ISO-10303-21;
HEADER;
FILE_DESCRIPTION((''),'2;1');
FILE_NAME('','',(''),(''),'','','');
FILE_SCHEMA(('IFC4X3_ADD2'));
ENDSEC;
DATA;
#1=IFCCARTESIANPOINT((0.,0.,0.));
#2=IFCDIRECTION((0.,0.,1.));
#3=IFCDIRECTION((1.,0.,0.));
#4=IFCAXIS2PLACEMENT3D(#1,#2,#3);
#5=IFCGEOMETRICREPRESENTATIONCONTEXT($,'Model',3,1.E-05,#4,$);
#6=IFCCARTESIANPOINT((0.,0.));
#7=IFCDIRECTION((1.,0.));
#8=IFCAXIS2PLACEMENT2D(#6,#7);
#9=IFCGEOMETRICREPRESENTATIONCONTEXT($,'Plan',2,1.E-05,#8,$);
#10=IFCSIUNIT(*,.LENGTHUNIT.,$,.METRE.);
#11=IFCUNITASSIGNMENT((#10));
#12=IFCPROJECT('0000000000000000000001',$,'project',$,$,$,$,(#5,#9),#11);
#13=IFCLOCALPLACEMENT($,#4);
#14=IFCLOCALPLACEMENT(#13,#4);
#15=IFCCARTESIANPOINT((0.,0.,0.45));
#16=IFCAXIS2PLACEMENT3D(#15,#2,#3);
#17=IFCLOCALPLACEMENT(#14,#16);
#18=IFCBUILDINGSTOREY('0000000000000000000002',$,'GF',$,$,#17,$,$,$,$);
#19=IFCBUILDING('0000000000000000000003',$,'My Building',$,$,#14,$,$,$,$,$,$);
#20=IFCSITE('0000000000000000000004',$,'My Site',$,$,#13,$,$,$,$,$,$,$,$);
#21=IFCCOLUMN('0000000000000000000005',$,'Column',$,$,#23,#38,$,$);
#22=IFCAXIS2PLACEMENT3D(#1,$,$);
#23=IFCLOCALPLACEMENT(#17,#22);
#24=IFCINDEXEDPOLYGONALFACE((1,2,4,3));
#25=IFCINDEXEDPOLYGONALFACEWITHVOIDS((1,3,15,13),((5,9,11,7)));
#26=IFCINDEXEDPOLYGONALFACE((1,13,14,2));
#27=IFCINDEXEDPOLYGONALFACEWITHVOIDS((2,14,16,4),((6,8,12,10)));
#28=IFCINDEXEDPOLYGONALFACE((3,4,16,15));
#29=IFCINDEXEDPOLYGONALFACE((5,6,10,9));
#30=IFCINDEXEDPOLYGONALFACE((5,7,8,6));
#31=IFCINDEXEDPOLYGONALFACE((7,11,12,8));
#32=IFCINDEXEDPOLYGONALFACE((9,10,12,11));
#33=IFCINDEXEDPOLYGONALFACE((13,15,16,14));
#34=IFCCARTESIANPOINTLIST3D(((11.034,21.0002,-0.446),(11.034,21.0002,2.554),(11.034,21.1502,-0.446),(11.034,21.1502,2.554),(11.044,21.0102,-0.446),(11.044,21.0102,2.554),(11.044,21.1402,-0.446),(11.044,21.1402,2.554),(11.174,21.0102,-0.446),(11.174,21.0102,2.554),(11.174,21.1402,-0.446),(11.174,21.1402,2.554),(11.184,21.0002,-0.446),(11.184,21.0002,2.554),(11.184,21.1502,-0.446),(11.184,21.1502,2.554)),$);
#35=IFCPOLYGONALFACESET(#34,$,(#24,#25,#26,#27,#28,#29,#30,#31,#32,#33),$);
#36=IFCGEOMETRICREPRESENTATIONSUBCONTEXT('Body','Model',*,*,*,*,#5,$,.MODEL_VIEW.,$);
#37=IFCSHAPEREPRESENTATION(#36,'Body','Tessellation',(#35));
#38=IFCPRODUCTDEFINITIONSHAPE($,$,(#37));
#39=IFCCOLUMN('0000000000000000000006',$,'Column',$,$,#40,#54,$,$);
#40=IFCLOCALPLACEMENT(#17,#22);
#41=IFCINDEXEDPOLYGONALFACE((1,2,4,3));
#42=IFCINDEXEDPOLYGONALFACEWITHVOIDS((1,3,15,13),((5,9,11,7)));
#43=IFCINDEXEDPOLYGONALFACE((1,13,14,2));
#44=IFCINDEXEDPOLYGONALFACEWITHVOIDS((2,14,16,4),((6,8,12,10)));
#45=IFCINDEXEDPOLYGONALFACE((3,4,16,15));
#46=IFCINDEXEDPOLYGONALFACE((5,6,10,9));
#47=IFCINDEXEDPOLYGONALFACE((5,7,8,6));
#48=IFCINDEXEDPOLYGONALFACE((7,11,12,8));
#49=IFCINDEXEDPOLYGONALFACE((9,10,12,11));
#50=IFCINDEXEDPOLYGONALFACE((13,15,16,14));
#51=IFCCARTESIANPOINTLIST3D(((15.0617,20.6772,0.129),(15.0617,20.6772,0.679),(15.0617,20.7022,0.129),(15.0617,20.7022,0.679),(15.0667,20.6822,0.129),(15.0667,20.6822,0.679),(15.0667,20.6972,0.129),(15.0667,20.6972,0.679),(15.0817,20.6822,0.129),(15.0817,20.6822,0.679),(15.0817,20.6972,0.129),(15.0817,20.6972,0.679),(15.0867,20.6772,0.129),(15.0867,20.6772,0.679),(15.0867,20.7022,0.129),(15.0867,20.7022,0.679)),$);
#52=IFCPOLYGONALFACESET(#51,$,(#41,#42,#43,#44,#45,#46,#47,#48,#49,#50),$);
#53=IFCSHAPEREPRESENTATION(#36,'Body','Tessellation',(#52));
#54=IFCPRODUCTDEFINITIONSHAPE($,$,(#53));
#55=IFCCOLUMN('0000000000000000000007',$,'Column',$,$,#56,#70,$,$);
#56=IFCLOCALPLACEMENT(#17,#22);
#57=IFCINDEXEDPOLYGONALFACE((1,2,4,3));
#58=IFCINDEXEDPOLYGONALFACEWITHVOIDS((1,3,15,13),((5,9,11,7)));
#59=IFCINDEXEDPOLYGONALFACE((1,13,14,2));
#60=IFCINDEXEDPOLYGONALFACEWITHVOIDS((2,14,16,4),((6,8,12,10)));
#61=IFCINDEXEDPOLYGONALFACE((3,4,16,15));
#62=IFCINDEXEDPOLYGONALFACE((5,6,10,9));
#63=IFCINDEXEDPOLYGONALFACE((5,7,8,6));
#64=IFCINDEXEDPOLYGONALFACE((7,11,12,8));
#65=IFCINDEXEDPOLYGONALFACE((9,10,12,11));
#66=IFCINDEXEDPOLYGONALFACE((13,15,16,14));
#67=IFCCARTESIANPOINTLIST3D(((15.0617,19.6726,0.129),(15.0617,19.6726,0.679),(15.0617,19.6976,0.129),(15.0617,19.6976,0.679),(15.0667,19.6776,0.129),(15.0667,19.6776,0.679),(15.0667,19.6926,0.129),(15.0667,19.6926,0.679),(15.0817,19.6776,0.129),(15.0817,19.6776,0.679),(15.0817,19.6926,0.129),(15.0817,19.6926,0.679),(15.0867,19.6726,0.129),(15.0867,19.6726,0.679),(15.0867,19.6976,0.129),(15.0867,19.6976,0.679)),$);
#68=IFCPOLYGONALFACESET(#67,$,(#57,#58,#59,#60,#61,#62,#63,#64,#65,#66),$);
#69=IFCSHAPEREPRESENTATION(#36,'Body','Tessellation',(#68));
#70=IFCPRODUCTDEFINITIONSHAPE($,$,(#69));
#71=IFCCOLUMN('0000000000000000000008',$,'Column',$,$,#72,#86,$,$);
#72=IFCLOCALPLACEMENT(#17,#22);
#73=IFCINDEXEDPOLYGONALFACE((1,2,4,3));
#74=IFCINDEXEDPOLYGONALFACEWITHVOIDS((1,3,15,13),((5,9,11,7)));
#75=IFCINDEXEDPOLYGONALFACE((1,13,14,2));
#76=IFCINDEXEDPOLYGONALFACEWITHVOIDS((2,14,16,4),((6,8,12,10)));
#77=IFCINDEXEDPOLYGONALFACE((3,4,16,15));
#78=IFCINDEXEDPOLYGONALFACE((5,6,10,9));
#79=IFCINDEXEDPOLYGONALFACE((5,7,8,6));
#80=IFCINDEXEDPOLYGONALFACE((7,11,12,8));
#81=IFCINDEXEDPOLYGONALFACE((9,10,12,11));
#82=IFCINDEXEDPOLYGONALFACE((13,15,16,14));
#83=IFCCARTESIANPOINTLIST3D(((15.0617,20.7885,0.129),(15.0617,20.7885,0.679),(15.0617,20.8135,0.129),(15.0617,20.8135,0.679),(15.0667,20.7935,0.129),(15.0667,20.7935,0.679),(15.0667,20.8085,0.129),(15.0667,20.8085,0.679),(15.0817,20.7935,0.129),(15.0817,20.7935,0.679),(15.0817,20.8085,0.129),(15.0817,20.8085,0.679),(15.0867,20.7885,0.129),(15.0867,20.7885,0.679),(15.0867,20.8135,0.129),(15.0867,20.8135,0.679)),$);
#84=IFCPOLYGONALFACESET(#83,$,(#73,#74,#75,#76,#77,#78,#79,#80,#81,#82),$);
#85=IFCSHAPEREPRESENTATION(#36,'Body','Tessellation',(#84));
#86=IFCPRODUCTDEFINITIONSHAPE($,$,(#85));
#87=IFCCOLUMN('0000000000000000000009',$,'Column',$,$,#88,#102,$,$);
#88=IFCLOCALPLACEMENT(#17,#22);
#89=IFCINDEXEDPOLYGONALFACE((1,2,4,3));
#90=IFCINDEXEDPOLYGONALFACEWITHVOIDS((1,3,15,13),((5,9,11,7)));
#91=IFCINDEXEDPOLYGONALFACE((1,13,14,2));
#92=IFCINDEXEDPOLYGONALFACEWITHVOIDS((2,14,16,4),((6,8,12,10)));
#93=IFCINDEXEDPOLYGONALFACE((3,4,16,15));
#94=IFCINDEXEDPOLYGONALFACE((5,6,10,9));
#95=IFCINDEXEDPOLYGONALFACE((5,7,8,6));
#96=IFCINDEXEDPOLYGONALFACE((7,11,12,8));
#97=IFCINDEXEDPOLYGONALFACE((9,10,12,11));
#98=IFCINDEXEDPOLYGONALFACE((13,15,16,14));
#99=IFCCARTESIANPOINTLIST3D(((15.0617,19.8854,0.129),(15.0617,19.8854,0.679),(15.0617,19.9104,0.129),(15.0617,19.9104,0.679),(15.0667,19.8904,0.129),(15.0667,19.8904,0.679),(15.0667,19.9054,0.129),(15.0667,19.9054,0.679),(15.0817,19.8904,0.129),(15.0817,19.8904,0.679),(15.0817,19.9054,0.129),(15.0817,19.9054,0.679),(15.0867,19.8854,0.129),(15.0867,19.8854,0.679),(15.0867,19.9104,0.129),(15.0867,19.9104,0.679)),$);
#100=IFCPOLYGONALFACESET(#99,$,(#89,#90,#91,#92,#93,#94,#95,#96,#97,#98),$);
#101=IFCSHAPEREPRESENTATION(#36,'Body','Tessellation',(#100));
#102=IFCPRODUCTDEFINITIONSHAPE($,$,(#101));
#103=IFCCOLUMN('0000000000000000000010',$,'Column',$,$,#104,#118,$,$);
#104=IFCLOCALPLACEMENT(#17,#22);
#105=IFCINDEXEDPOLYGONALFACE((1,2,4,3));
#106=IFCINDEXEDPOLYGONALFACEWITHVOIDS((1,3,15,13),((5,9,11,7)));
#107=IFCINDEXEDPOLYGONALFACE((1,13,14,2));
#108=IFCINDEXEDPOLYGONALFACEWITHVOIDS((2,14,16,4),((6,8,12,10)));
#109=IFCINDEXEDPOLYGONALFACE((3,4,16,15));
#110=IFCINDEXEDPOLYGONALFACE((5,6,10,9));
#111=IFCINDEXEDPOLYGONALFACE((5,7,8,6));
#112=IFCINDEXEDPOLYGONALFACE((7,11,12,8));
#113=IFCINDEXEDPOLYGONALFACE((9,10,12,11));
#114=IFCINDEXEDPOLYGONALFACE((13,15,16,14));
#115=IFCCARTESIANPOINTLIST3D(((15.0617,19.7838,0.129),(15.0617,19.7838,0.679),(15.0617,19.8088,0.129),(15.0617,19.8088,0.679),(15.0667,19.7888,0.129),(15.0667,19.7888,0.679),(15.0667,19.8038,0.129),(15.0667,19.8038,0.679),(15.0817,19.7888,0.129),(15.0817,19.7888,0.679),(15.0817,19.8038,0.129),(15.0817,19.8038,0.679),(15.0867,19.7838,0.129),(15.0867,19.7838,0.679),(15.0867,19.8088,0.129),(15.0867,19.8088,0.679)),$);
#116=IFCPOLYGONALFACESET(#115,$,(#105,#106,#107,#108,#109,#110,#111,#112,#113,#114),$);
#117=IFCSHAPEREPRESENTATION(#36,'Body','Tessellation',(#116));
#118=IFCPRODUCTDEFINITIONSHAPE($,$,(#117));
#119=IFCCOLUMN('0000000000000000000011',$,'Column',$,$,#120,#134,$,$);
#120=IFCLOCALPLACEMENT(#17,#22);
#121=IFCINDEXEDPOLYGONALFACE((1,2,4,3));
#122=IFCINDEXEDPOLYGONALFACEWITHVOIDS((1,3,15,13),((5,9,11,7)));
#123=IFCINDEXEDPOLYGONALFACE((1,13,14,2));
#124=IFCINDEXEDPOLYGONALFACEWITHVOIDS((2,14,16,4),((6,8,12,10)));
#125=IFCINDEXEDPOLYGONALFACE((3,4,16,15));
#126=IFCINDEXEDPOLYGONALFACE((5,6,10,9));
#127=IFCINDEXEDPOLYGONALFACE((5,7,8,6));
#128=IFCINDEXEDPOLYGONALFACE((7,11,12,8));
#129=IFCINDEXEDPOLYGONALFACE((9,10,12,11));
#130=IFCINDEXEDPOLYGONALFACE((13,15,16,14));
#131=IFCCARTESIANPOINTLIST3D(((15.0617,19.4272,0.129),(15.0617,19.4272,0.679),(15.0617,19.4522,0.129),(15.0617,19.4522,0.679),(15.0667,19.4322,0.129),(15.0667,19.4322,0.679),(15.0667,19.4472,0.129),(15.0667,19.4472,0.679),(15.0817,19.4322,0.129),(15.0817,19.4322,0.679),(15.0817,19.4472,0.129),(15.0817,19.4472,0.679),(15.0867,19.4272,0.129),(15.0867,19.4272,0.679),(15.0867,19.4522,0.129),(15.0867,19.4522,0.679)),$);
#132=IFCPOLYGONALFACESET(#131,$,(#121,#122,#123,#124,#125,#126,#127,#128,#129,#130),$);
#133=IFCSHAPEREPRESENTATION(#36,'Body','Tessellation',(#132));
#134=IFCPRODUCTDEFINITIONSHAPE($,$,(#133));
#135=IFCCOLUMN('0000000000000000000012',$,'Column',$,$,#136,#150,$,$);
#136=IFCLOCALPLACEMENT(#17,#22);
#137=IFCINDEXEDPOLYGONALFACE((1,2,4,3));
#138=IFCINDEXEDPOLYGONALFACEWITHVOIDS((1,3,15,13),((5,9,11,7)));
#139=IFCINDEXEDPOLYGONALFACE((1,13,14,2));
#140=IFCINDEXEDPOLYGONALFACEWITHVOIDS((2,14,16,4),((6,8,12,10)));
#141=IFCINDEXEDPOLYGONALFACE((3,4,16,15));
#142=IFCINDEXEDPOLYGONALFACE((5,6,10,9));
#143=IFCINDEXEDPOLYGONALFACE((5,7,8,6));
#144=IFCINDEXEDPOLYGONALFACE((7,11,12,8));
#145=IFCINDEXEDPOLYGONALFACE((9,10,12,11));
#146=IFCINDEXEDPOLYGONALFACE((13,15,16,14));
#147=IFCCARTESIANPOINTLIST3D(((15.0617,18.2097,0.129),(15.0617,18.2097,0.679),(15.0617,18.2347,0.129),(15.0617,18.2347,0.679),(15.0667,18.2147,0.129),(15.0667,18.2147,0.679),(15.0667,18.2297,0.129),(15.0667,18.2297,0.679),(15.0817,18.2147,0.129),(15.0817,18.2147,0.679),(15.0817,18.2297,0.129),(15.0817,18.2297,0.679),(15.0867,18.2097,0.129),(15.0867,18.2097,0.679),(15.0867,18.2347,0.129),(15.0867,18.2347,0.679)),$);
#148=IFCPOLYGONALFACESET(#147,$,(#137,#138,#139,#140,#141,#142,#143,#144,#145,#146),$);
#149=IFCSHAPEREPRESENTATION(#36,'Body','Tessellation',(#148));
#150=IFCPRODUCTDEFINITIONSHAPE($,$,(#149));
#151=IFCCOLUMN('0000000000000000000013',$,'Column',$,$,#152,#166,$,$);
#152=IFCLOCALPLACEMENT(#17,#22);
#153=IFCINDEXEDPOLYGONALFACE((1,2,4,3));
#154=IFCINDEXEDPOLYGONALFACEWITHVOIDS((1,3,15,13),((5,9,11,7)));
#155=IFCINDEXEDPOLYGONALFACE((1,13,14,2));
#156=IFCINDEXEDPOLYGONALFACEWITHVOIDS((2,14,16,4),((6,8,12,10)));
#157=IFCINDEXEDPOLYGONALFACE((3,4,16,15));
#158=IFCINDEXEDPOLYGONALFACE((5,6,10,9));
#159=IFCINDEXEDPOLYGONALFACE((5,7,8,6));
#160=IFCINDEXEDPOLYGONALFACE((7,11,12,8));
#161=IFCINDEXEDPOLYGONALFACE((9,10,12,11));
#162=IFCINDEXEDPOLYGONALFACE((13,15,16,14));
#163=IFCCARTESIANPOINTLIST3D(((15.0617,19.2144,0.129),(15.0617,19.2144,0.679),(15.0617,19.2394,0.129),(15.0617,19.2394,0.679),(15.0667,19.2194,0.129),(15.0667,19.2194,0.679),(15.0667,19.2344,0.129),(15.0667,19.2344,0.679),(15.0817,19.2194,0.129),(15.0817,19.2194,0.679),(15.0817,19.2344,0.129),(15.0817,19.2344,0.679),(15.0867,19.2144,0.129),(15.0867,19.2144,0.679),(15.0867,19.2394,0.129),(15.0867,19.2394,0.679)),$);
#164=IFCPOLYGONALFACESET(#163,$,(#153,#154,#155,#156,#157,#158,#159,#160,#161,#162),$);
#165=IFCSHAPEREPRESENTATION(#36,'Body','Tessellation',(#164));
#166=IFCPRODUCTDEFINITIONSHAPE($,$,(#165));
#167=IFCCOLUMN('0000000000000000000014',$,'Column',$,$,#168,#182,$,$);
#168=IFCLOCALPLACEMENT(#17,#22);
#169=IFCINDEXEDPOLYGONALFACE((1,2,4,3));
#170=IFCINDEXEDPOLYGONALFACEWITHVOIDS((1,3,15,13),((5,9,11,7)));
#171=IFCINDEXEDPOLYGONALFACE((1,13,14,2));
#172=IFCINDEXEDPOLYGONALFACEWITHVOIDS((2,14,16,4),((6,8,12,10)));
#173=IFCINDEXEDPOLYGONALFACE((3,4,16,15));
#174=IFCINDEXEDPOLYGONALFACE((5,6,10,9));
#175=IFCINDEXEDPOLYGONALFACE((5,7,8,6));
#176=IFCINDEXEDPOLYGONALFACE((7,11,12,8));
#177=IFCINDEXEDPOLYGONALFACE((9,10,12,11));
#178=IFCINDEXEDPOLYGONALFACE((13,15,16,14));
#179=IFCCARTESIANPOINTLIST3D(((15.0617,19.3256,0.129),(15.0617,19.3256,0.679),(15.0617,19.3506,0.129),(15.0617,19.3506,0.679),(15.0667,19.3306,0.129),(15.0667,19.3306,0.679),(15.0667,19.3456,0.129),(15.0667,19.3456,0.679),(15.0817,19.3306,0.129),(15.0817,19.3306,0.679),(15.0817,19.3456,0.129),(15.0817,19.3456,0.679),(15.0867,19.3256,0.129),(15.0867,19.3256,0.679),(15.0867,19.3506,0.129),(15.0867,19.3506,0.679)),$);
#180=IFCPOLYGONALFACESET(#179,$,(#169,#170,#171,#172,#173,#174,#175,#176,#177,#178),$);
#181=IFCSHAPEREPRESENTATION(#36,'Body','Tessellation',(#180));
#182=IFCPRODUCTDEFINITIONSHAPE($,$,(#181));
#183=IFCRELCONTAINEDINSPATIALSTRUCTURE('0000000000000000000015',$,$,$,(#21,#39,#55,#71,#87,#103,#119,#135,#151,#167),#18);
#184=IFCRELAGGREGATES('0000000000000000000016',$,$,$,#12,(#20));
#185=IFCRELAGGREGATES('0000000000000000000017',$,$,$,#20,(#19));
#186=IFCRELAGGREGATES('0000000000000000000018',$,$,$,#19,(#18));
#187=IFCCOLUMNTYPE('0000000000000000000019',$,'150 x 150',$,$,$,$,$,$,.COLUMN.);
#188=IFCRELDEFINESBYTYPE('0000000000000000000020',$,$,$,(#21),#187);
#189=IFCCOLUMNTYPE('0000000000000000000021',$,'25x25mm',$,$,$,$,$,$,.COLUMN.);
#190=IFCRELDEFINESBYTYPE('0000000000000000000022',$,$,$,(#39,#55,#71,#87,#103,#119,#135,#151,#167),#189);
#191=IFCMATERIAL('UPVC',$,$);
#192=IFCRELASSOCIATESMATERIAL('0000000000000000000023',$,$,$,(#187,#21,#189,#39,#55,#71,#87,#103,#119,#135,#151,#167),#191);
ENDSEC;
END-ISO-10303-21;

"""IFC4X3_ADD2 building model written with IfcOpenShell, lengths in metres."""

from ifc_helpers import new_model, entity, si_unit, frame, origin_with_axes, origin_2d_with_axis, place, context, subcontext, project, spatial, hollow_rectangle, extrude, shape, material, material_profile, profile_set, profile_usage, type_object, element, save


model = new_model("IFC4X3_ADD2")

# Units and contexts
model_context = context("Model", 3, precision=1e-05, world=origin_with_axes())
plan_context = context("Plan", 2, precision=1e-05, world=origin_2d_with_axis())
body_context_1 = subcontext(model_context, "Body", "Model", "MODEL_VIEW")
body_context_2 = subcontext(plan_context, "Body", "Plan", "PLAN_VIEW")
ifc_project = project(units=[si_unit("LENGTHUNIT", "METRE")], contexts=[model_context, plan_context])

# Site, building, storey
site_placement = place(None, origin_with_axes())
site = spatial("IfcSite", under=ifc_project, at=site_placement, Name="My Site")
building_placement = place(site_placement, origin_with_axes())
building = spatial("IfcBuilding", under=site, at=building_placement, Name="My Building")
storey_placement = place(building_placement, frame((0.0, 0.0, 0.45), z_axis=(0.0, 0.0, 1.0), x_axis=(1.0, 0.0, 0.0)))
storey = spatial("IfcBuildingStorey", under=building, at=storey_placement, Name="GF")

# Columns
ifc_material_1 = material(Name="UPVC")
ifc_material_profile_1 = material_profile(ifc_material_1, hollow_rectangle(XDim=0.15, YDim=0.15, WallThickness=0.01))
ifc_profile_set_1 = profile_set([ifc_material_profile_1])
ifc_profile_usage_1 = profile_usage(ifc_profile_set_1)
column_type_1 = type_object("IfcColumnType", Name="150 x 150", PredefinedType="COLUMN", material=ifc_profile_set_1)
column_1_placement = place(storey_placement, frame((11.109, 21.0752, -0.446), z_axis=(0.0, 0.0, 1.0), x_axis=(1.0, 0.0, 0.0)))
element("IfcColumn", 1, at=column_1_placement, inside=storey, type_object=column_type_1, material=ifc_profile_usage_1, Name="Column", shapes=[
    shape(body_context_1, "Body", "SweptSolid", [extrude(hollow_rectangle(XDim=0.15, YDim=0.15, WallThickness=0.01), origin_with_axes(), (0.0, 0.0, 1.0), 3.0)]),
    shape(body_context_2, "Body", "Annotation2D", [entity("IfcGeometricCurveSet", [entity("IfcIndexedPolyCurve", entity("IfcCartesianPointList2D", [[0.075, 0.075], [0.075, -0.075], [-0.075, -0.075], [-0.075, 0.075]]), [entity("IfcLineIndex", [1, 2, 3, 4, 1])]), entity("IfcIndexedPolyCurve", entity("IfcCartesianPointList2D", [[0.065, -0.065], [0.065, 0.065], [-0.065, 0.065], [-0.065, -0.065]]), [entity("IfcLineIndex", [1, 2, 3, 4, 1])])])]),
])
ifc_material_profile_2 = material_profile(ifc_material_1, hollow_rectangle(XDim=0.025, YDim=0.025, WallThickness=0.005))
ifc_profile_set_2 = profile_set([ifc_material_profile_2])
ifc_profile_usage_2 = profile_usage(ifc_profile_set_2)
column_type_2 = type_object("IfcColumnType", Name="25x25mm", PredefinedType="COLUMN", material=ifc_profile_set_2)
column_2_placement = place(storey_placement, frame((15.0742, 20.6897, 0.129), z_axis=(0.0, 0.0, 1.0), x_axis=(0.0, -1.0, 0.0)))
element("IfcColumn", 2, at=column_2_placement, inside=storey, type_object=column_type_2, material=ifc_profile_usage_2, Name="Column", context=body_context_1, shape_type="SweptSolid", body=[
    extrude(hollow_rectangle(XDim=0.025, YDim=0.025, WallThickness=0.005), origin_with_axes(), (0.0, 0.0, 1.0), 0.55),
])
ifc_profile_usage_3 = profile_usage(ifc_profile_set_2)
column_3_placement = place(storey_placement, frame((15.0742, 19.6851, 0.129), z_axis=(0.0, 0.0, 1.0), x_axis=(0.0, -1.0, 0.0)))
element("IfcColumn", 3, at=column_3_placement, inside=storey, type_object=column_type_2, material=ifc_profile_usage_3, Name="Column", context=body_context_1, shape_type="SweptSolid", body=[
    extrude(hollow_rectangle(XDim=0.025, YDim=0.025, WallThickness=0.005), origin_with_axes(), (0.0, 0.0, 1.0), 0.55),
])
ifc_profile_usage_4 = profile_usage(ifc_profile_set_2)
column_4_placement = place(storey_placement, frame((15.0742, 20.801, 0.129), z_axis=(0.0, 0.0, 1.0), x_axis=(0.0, -1.0, 0.0)))
element("IfcColumn", 4, at=column_4_placement, inside=storey, type_object=column_type_2, material=ifc_profile_usage_4, Name="Column", context=body_context_1, shape_type="SweptSolid", body=[
    extrude(hollow_rectangle(XDim=0.025, YDim=0.025, WallThickness=0.005), origin_with_axes(), (0.0, 0.0, 1.0), 0.55),
])
ifc_profile_usage_5 = profile_usage(ifc_profile_set_2)
column_5_placement = place(storey_placement, frame((15.0742, 19.8979, 0.129), z_axis=(0.0, 0.0, 1.0), x_axis=(0.0, -1.0, 0.0)))
element("IfcColumn", 5, at=column_5_placement, inside=storey, type_object=column_type_2, material=ifc_profile_usage_5, Name="Column", context=body_context_1, shape_type="SweptSolid", body=[
    extrude(hollow_rectangle(XDim=0.025, YDim=0.025, WallThickness=0.005), origin_with_axes(), (0.0, 0.0, 1.0), 0.55),
])
ifc_profile_usage_6 = profile_usage(ifc_profile_set_2)
column_6_placement = place(storey_placement, frame((15.0742, 19.7963, 0.129), z_axis=(0.0, 0.0, 1.0), x_axis=(0.0, -1.0, 0.0)))
element("IfcColumn", 6, at=column_6_placement, inside=storey, type_object=column_type_2, material=ifc_profile_usage_6, Name="Column", context=body_context_1, shape_type="SweptSolid", body=[
    extrude(hollow_rectangle(XDim=0.025, YDim=0.025, WallThickness=0.005), origin_with_axes(), (0.0, 0.0, 1.0), 0.55),
])
ifc_profile_usage_7 = profile_usage(ifc_profile_set_2)
column_7_placement = place(storey_placement, frame((15.0742, 19.4397, 0.129), z_axis=(0.0, 0.0, 1.0), x_axis=(0.0, -1.0, 0.0)))
element("IfcColumn", 7, at=column_7_placement, inside=storey, type_object=column_type_2, material=ifc_profile_usage_7, Name="Column", context=body_context_1, shape_type="SweptSolid", body=[
    extrude(hollow_rectangle(XDim=0.025, YDim=0.025, WallThickness=0.005), origin_with_axes(), (0.0, 0.0, 1.0), 0.55),
])
ifc_profile_usage_8 = profile_usage(ifc_profile_set_2)
column_8_placement = place(storey_placement, frame((15.0742, 18.2222, 0.129), z_axis=(0.0, 0.0, 1.0), x_axis=(0.0, -1.0, 0.0)))
element("IfcColumn", 8, at=column_8_placement, inside=storey, type_object=column_type_2, material=ifc_profile_usage_8, Name="Column", context=body_context_1, shape_type="SweptSolid", body=[
    extrude(hollow_rectangle(XDim=0.025, YDim=0.025, WallThickness=0.005), origin_with_axes(), (0.0, 0.0, 1.0), 0.55),
])
ifc_profile_usage_9 = profile_usage(ifc_profile_set_2)
column_9_placement = place(storey_placement, frame((15.0742, 19.2269, 0.129), z_axis=(0.0, 0.0, 1.0), x_axis=(0.0, -1.0, 0.0)))
element("IfcColumn", 9, at=column_9_placement, inside=storey, type_object=column_type_2, material=ifc_profile_usage_9, Name="Column", context=body_context_1, shape_type="SweptSolid", body=[
    extrude(hollow_rectangle(XDim=0.025, YDim=0.025, WallThickness=0.005), origin_with_axes(), (0.0, 0.0, 1.0), 0.55),
])
ifc_profile_usage_10 = profile_usage(ifc_profile_set_2)
column_10_placement = place(storey_placement, frame((15.0742, 19.3381, 0.129), z_axis=(0.0, 0.0, 1.0), x_axis=(0.0, -1.0, 0.0)))
element("IfcColumn", 10, at=column_10_placement, inside=storey, type_object=column_type_2, material=ifc_profile_usage_10, Name="Column", context=body_context_1, shape_type="SweptSolid", body=[
    extrude(hollow_rectangle(XDim=0.025, YDim=0.025, WallThickness=0.005), origin_with_axes(), (0.0, 0.0, 1.0), 0.55),
])

save(model, "model.ifc")
